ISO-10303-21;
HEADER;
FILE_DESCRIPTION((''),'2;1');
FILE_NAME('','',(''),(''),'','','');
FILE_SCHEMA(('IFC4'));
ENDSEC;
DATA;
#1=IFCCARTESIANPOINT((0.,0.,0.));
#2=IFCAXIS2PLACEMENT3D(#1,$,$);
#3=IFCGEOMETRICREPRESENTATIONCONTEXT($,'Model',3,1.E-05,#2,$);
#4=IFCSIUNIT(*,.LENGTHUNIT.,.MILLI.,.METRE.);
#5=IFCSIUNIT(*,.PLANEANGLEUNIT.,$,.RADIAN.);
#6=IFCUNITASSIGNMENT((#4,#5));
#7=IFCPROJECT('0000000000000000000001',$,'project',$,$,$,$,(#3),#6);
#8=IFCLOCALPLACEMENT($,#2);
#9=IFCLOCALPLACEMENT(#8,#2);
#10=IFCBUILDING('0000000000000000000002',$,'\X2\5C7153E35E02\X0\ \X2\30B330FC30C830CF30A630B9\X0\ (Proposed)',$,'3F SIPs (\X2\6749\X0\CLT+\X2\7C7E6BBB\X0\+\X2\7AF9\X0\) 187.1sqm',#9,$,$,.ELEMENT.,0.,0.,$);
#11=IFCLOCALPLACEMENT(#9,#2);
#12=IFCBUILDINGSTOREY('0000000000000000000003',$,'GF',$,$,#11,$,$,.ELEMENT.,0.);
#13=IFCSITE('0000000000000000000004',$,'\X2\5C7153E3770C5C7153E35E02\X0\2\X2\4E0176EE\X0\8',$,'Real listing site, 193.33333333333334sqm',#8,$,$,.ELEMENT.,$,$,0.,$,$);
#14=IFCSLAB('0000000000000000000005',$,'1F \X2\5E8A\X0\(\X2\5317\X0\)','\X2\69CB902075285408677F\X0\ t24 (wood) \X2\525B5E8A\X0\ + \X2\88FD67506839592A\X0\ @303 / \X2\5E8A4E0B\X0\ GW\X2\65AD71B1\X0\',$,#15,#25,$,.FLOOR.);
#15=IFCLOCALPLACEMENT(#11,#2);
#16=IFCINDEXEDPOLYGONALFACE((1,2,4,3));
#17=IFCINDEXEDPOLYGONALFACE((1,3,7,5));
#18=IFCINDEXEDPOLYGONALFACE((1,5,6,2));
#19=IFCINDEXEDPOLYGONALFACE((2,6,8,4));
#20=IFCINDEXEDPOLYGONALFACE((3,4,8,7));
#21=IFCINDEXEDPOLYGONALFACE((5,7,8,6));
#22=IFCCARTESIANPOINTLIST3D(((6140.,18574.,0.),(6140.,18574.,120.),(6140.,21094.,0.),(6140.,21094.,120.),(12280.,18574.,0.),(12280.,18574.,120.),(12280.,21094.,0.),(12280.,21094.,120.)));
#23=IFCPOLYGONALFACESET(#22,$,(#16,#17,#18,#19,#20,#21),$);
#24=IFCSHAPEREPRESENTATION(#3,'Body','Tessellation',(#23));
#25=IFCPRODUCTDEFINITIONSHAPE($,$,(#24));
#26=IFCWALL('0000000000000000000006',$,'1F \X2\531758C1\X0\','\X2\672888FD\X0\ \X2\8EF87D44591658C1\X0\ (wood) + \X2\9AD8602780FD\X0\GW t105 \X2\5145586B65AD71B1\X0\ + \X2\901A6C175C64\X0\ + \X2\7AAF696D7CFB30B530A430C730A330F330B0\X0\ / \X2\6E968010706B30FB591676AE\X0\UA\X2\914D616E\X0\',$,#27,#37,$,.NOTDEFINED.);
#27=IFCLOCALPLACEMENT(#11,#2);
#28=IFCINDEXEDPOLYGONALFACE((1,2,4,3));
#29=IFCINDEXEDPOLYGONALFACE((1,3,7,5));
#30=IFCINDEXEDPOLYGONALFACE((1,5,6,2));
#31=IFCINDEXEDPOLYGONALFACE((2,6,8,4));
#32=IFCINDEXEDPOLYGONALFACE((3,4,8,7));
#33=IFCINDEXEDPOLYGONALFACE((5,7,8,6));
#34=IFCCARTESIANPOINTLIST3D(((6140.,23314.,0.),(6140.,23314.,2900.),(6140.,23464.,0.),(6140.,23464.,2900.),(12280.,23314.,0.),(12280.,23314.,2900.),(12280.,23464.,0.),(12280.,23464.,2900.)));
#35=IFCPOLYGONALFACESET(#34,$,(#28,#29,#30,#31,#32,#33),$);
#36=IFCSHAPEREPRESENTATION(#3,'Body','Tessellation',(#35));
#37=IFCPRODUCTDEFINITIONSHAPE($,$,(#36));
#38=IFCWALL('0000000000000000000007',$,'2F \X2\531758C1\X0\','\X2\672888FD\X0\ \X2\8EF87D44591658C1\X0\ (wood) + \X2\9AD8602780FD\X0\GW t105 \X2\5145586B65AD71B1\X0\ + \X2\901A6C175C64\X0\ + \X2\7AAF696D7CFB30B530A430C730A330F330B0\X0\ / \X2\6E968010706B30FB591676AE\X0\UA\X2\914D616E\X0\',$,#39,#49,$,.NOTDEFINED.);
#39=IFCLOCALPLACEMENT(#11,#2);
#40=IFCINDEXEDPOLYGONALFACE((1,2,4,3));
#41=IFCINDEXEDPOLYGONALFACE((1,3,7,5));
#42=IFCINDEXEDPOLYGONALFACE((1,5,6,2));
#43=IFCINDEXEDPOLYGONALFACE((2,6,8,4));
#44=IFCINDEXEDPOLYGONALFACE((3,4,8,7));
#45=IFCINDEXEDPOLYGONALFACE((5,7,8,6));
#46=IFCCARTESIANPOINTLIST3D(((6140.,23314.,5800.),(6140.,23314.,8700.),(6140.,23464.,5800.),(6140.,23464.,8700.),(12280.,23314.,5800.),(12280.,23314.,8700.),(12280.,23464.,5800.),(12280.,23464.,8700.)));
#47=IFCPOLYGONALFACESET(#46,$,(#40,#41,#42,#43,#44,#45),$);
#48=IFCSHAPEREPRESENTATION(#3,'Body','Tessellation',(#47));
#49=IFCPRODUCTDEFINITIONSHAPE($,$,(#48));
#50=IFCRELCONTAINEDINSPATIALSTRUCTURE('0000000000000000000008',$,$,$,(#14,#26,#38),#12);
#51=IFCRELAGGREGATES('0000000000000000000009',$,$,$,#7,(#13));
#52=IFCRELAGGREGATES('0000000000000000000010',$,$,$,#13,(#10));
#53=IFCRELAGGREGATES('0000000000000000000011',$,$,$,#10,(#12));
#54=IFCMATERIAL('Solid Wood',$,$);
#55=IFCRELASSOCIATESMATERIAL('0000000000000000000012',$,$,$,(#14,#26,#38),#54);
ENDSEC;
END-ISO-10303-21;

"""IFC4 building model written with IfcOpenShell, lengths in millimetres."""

from ifc_helpers import new_model, si_unit, frame, frame_2d, origin, place, context, project, spatial, rectangle, extrude, material, element, save


model = new_model("IFC4")

# Units and contexts
model_context = context("Model", 3, precision=1e-05, world=origin())
ifc_project = project(units=[si_unit("LENGTHUNIT", "METRE", prefix="MILLI"), si_unit("PLANEANGLEUNIT", "RADIAN")], contexts=[model_context])

# Site, building, storey
site_placement = place(None, origin())
site = spatial("IfcSite", under=ifc_project, at=site_placement, Name="山口県山口市2丁目8", ObjectType="Real listing site, 193.33333333333334sqm", CompositionType="ELEMENT", RefElevation=0.0)
building_placement = place(site_placement, origin())
building = spatial("IfcBuilding", under=site, at=building_placement, Name="山口市 コートハウス (Proposed)", ObjectType="3F SIPs (杉CLT+籾殻+竹) 187.1sqm", CompositionType="ELEMENT", ElevationOfRefHeight=0.0, ElevationOfTerrain=0.0)
storey_placement = place(building_placement, origin())
storey = spatial("IfcBuildingStorey", under=building, at=storey_placement, Name="GF", CompositionType="ELEMENT", Elevation=0.0)

# Slab
ifc_material_1 = material(Name="Solid Wood")
slab_1_placement = place(storey_placement, frame((3070.0, 9287.0, 0.0)))
element("IfcSlab", 1, at=slab_1_placement, inside=storey, material=ifc_material_1, Name="1F 床(北)", Description="構造用合板 t24 (wood) 剛床 + 製材根太 @303 / 床下 GW断熱", PredefinedType="FLOOR", context=model_context, shape_type="SweptSolid", body=[
    extrude(rectangle(XDim=6140.0, YDim=2520.0, at=frame_2d((3070.0, 1260.0))), frame((3070.0, 9287.0, 0.0)), (0.0, 0.0, 1.0), 120.0),
])

# Wall
wall_1_placement = place(storey_placement, frame((3070.0, 11657.0, 0.0)))
element("IfcWall", 2, at=wall_1_placement, inside=storey, material=ifc_material_1, Name="1F 北壁", Description="木製 軸組外壁 (wood) + 高性能GW t105 充填断熱 + 通気層 + 窯業系サイディング / 準耐火・外皮UA配慮", PredefinedType="NOTDEFINED", context=model_context, shape_type="SweptSolid", body=[
    extrude(rectangle(XDim=6140.0, YDim=150.0, at=frame_2d((3070.0, 75.0))), frame((3070.0, 11657.0, 0.0)), (0.0, 0.0, 1.0), 2900.0),
])

# Wall
wall_2_placement = place(storey_placement, frame((3070.0, 11657.0, 2900.0)))
element("IfcWall", 3, at=wall_2_placement, inside=storey, material=ifc_material_1, Name="2F 北壁", Description="木製 軸組外壁 (wood) + 高性能GW t105 充填断熱 + 通気層 + 窯業系サイディング / 準耐火・外皮UA配慮", PredefinedType="NOTDEFINED", context=model_context, shape_type="SweptSolid", body=[
    extrude(rectangle(XDim=6140.0, YDim=150.0, at=frame_2d((3070.0, 75.0))), frame((3070.0, 11657.0, 2900.0)), (0.0, 0.0, 1.0), 2900.0),
])

save(model, "model.ifc")
